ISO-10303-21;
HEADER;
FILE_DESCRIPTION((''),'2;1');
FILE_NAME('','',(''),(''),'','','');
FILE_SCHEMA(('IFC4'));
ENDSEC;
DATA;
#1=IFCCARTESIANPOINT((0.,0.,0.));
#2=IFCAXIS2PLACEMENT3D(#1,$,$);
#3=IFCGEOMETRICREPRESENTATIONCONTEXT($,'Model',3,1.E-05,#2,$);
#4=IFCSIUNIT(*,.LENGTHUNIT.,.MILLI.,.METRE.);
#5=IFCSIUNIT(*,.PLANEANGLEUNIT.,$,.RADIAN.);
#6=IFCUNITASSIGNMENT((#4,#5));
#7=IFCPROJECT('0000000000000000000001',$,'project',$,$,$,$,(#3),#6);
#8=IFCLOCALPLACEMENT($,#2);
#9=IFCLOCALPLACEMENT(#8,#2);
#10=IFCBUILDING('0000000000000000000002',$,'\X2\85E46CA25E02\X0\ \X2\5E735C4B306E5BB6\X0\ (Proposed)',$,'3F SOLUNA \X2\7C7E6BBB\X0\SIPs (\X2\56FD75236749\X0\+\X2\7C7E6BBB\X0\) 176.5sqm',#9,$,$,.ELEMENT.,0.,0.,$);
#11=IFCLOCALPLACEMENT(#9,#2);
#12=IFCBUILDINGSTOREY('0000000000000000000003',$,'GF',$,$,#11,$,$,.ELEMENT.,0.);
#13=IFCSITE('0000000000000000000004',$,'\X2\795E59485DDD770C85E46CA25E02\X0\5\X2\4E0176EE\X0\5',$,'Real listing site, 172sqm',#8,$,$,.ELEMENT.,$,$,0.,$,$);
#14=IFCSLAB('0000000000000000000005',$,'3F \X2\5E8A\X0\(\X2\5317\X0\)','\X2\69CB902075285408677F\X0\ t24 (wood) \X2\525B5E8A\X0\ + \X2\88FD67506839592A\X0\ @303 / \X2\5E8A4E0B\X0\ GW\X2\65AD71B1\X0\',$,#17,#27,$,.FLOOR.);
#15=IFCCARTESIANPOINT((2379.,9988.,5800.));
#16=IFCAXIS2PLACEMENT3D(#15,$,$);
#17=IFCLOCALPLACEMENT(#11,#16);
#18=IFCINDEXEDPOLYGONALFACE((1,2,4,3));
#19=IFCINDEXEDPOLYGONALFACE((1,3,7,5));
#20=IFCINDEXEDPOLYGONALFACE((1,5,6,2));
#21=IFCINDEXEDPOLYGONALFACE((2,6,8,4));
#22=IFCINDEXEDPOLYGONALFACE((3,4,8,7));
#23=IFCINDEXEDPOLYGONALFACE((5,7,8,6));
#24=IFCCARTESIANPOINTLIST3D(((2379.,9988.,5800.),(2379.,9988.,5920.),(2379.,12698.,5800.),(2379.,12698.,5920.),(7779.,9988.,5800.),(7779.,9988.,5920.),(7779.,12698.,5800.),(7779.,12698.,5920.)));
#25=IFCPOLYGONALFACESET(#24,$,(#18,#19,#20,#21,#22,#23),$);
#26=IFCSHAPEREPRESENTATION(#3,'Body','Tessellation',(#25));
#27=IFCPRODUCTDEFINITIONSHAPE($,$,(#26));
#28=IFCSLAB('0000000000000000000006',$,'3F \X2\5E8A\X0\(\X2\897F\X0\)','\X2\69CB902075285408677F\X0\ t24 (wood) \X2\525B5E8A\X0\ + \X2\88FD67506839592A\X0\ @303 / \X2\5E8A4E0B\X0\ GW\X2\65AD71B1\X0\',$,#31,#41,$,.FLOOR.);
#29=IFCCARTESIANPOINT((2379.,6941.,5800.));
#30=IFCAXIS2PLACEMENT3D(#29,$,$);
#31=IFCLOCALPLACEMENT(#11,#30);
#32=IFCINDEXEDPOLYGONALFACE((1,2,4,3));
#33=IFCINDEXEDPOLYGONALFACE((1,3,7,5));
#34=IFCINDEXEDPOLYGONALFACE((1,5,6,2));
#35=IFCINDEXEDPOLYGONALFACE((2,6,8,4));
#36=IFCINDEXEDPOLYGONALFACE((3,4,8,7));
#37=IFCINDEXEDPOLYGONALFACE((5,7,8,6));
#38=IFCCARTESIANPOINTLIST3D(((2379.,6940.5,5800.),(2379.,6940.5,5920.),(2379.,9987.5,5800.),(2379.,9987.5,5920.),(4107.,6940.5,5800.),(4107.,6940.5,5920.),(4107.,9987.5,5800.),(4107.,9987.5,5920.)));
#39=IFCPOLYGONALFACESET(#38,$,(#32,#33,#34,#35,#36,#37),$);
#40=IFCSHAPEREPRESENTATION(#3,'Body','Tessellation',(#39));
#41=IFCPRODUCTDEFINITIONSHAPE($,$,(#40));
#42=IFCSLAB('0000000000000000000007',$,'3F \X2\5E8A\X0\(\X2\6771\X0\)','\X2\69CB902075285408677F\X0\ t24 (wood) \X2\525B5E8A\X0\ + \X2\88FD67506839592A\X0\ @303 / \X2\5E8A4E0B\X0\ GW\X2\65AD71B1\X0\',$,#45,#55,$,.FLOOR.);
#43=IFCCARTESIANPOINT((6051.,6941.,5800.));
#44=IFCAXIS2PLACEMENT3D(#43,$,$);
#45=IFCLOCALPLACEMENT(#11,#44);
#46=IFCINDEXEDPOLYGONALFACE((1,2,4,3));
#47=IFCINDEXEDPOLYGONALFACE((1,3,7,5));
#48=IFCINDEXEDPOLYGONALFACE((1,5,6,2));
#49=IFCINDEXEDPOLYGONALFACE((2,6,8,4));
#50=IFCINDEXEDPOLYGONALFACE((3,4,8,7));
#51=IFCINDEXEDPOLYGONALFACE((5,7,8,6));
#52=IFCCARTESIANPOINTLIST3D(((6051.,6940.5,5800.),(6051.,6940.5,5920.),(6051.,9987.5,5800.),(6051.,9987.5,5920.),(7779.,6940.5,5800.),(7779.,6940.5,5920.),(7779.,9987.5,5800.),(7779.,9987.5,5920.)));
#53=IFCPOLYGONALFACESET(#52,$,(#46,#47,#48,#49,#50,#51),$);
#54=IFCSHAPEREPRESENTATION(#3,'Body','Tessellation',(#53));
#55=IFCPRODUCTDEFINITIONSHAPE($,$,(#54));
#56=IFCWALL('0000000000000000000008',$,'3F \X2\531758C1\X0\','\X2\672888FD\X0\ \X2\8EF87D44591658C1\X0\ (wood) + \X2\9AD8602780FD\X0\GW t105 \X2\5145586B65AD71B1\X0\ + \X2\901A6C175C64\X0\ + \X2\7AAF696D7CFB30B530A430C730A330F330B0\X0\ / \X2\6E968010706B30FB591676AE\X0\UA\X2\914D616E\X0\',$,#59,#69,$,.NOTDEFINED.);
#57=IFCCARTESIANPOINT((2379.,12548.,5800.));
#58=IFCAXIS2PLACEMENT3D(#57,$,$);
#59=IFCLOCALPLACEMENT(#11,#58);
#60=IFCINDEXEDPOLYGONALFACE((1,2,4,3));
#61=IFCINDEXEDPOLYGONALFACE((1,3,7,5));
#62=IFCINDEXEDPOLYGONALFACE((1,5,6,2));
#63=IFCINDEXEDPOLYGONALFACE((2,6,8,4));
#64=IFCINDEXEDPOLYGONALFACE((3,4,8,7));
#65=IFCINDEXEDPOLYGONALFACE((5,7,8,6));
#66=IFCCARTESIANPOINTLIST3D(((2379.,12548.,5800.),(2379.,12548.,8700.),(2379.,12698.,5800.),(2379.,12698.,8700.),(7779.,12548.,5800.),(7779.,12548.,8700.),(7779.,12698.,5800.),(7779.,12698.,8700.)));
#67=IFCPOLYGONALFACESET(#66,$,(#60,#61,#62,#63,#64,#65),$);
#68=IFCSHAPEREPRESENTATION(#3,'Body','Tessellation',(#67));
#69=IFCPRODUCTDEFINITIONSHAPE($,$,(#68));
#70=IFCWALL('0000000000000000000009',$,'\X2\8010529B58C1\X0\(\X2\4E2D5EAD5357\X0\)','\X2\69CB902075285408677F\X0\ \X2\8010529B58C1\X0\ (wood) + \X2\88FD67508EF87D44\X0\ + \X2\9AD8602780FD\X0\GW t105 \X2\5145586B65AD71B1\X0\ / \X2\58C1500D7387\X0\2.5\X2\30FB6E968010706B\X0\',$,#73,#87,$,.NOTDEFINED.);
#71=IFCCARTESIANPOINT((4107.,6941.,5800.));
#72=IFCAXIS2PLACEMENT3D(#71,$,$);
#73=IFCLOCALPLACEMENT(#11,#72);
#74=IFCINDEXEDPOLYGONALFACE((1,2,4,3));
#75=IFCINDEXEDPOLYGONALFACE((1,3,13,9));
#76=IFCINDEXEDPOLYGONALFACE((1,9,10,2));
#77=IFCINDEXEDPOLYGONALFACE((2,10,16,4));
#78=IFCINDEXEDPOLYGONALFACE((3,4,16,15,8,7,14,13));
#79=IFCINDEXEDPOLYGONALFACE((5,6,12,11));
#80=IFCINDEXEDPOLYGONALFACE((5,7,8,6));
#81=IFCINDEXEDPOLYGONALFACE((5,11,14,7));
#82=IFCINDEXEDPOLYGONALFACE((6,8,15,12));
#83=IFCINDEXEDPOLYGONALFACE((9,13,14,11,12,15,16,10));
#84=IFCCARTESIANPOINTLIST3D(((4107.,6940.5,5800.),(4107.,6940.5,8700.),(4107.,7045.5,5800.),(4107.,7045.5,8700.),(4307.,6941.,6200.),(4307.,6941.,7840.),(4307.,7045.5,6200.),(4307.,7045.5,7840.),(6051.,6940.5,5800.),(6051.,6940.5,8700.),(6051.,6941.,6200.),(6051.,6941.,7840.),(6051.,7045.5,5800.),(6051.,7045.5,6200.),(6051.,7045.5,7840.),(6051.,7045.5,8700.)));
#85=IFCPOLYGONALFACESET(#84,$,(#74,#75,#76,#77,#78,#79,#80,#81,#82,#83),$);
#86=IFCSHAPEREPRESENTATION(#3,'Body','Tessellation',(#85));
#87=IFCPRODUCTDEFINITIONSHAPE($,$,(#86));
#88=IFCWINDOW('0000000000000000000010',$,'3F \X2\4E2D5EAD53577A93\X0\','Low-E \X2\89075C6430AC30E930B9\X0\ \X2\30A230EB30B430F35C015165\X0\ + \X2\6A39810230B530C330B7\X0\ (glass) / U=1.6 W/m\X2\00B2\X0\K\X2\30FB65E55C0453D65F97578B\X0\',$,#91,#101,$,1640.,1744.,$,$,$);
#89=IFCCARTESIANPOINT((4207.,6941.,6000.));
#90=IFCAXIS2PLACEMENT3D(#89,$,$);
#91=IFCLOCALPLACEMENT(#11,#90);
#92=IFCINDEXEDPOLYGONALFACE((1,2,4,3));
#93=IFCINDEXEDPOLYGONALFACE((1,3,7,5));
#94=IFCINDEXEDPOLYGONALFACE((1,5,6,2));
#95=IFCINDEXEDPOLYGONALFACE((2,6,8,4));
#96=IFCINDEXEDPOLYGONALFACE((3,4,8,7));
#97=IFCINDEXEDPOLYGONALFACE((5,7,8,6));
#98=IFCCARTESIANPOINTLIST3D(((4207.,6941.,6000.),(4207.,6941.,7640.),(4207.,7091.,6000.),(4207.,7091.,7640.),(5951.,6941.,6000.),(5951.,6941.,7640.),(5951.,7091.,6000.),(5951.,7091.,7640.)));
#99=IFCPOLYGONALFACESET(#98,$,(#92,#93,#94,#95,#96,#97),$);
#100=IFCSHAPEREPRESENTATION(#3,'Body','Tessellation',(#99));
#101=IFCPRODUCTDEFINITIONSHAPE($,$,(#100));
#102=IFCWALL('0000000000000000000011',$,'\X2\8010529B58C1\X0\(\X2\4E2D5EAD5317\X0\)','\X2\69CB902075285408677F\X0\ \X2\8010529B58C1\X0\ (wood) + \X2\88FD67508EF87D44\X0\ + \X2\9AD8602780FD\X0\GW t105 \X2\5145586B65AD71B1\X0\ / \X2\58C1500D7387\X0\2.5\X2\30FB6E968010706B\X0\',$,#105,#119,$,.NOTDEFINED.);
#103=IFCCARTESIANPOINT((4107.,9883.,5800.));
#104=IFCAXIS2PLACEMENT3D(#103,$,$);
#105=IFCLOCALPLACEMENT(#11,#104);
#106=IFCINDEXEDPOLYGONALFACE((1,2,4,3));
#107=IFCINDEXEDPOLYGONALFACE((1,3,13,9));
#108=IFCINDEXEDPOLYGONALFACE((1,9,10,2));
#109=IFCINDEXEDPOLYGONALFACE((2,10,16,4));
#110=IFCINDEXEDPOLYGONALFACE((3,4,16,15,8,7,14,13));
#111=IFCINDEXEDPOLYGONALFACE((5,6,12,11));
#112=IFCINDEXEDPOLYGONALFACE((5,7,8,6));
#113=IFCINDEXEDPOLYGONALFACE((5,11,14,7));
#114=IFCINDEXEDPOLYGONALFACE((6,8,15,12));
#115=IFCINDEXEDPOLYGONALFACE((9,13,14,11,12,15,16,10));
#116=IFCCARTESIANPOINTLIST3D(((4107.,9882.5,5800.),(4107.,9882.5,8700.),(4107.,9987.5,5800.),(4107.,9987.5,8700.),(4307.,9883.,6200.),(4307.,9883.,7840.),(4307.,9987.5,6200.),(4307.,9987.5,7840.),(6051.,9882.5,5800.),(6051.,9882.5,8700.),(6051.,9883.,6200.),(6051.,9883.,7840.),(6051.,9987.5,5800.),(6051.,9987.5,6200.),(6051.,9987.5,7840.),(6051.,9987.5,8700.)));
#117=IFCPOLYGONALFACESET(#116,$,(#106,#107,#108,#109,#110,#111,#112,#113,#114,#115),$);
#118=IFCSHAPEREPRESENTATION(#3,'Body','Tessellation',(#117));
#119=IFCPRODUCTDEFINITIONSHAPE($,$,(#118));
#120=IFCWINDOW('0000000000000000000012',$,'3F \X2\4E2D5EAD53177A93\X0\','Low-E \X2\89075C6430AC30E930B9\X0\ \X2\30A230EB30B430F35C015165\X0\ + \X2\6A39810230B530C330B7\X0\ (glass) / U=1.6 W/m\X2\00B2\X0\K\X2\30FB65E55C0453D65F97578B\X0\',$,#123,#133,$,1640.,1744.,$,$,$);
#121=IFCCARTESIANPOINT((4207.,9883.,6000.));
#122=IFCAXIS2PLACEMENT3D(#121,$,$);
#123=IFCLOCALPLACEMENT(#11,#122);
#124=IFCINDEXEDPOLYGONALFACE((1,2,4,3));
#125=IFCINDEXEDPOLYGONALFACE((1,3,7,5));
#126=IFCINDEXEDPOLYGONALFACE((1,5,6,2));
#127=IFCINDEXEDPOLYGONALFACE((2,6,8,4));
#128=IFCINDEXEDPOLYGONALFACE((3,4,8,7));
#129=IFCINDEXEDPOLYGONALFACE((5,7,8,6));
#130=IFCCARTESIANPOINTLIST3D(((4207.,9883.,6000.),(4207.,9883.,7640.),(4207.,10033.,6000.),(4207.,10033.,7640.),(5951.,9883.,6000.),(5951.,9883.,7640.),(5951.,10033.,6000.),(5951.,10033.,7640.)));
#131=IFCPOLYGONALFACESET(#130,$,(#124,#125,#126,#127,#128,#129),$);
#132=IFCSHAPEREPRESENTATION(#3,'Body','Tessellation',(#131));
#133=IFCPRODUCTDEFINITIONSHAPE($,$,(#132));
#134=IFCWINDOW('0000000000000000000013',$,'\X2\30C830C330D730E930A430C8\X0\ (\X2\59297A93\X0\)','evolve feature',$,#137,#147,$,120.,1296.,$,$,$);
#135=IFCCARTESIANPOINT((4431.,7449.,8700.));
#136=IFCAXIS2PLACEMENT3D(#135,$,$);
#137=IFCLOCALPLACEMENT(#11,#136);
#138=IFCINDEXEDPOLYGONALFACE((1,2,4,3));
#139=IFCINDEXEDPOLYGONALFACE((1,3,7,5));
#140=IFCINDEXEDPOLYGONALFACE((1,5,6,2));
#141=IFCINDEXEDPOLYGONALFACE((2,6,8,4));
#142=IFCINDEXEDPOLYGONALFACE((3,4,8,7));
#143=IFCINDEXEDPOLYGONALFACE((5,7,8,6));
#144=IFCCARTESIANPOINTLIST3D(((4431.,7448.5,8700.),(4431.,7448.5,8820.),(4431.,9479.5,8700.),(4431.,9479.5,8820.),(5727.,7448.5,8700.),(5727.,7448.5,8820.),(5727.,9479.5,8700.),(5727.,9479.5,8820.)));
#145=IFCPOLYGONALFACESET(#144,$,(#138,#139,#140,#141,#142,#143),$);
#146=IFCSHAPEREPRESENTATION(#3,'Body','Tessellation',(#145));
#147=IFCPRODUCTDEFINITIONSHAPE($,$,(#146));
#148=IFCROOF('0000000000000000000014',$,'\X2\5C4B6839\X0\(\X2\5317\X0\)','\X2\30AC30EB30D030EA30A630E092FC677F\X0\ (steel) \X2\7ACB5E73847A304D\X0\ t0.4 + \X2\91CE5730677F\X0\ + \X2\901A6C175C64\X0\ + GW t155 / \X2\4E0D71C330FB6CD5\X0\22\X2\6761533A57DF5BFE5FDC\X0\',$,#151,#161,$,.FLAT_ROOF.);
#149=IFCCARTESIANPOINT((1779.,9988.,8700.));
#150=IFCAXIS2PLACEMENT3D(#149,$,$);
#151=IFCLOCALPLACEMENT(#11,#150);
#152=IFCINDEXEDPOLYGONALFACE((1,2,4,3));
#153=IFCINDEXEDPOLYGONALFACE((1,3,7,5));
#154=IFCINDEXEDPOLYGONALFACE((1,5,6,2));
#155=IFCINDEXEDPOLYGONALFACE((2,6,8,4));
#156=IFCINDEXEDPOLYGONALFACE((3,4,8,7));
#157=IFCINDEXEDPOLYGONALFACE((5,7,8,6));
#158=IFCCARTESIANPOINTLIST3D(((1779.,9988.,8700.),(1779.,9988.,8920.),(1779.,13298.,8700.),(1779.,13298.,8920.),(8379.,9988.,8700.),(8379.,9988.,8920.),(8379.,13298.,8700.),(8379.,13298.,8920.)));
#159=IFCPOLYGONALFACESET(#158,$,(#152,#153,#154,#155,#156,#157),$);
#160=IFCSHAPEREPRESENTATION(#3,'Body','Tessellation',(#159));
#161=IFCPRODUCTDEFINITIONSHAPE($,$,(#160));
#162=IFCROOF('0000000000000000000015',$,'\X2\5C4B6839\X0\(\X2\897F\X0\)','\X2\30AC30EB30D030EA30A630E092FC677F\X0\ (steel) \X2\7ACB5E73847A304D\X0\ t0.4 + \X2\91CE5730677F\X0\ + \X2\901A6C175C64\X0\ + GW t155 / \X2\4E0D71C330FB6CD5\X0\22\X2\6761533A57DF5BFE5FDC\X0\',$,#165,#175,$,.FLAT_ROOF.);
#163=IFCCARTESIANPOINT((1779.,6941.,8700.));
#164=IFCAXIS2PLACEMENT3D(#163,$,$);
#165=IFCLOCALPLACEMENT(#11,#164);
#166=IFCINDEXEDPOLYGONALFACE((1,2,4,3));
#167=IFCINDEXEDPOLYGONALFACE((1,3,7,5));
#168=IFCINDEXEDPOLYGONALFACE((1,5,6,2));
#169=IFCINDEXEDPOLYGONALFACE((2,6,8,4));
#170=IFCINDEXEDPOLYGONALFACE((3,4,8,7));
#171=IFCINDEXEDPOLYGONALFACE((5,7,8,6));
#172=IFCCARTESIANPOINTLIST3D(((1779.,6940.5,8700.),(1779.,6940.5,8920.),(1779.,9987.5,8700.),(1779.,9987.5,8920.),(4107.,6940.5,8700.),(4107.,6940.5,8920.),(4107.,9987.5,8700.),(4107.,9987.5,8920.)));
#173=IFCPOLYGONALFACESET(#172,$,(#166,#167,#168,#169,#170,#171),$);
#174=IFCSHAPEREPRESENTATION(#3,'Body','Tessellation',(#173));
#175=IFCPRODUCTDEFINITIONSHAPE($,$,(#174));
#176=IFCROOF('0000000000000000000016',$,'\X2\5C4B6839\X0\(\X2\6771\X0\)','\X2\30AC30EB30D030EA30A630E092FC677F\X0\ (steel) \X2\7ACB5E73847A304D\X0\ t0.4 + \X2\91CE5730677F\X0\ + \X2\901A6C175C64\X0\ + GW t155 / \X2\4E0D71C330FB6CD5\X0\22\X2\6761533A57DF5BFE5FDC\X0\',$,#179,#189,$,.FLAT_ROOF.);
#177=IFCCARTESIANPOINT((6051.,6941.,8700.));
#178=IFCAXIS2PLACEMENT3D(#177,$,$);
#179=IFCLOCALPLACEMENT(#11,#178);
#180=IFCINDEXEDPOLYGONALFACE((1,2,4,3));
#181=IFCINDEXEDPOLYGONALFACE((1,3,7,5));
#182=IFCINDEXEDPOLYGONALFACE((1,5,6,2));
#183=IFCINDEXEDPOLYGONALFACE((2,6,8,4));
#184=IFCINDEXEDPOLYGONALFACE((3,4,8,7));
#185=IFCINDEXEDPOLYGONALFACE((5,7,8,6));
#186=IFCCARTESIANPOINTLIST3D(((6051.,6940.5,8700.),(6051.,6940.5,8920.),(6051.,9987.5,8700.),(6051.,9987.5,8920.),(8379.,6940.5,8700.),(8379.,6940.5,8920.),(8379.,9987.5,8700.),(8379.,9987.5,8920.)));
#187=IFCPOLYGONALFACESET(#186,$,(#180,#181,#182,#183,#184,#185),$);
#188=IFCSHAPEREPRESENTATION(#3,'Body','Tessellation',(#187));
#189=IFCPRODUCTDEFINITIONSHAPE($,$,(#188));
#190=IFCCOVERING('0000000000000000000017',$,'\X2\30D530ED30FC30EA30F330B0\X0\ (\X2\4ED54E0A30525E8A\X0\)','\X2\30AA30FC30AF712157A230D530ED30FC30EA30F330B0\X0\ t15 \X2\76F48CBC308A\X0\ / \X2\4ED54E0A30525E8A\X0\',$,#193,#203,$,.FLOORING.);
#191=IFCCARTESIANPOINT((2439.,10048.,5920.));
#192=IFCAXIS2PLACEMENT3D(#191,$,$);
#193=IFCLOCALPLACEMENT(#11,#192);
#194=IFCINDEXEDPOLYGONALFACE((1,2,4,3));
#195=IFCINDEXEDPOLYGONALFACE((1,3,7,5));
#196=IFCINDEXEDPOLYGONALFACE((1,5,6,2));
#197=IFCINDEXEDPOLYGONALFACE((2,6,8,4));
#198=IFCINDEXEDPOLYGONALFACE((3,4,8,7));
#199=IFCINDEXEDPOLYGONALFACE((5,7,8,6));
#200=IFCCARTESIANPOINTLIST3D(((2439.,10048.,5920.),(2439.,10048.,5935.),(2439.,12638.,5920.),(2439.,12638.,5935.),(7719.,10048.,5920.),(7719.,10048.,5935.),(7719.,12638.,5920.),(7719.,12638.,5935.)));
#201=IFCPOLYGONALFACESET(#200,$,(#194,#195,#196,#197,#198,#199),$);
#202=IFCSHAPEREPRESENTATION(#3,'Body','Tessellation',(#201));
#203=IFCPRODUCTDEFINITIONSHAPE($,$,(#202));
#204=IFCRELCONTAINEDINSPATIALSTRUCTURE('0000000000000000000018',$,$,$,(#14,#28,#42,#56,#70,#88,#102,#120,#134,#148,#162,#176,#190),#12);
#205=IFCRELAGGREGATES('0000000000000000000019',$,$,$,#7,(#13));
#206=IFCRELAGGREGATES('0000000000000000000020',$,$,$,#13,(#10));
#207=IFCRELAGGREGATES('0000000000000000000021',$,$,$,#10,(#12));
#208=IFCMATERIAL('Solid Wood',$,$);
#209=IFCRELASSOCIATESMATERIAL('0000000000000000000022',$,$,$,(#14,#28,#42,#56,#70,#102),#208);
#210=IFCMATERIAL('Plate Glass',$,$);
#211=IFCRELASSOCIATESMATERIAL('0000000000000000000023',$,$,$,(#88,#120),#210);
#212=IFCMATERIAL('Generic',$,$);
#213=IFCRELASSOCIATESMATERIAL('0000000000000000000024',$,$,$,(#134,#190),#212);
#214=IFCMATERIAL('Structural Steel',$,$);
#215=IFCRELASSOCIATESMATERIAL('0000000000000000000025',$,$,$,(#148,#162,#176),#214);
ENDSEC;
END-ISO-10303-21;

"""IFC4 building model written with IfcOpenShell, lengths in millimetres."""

from ifc_helpers import new_model, si_unit, frame, frame_2d, origin, place, context, project, spatial, rectangle, extrude, material, element, fill, save


model = new_model("IFC4")

# Units and contexts
model_context = context("Model", 3, precision=1e-05, world=origin())
ifc_project = project(units=[si_unit("LENGTHUNIT", "METRE", prefix="MILLI"), si_unit("PLANEANGLEUNIT", "RADIAN")], contexts=[model_context])

# Site, building, storey
site_placement = place(None, origin())
site = spatial("IfcSite", under=ifc_project, at=site_placement, Name="神奈川県藤沢市5丁目5", ObjectType="Real listing site, 172sqm", CompositionType="ELEMENT", RefElevation=0.0)
building_placement = place(site_placement, origin())
building = spatial("IfcBuilding", under=site, at=building_placement, Name="藤沢市 平屋の家 (Proposed)", ObjectType="3F SOLUNA 籾殻SIPs (国産杉+籾殻) 176.5sqm", CompositionType="ELEMENT", ElevationOfRefHeight=0.0, ElevationOfTerrain=0.0)
storey_placement = place(building_placement, origin())
storey = spatial("IfcBuildingStorey", under=building, at=storey_placement, Name="GF", CompositionType="ELEMENT", Elevation=0.0)

# Slabs
ifc_material_1 = material(Name="Solid Wood")
slab_1_placement = place(storey_placement, frame((2379.0, 9988.0, 5800.0)))
element("IfcSlab", 1, at=slab_1_placement, inside=storey, material=ifc_material_1, Name="3F 床(北)", Description="構造用合板 t24 (wood) 剛床 + 製材根太 @303 / 床下 GW断熱", PredefinedType="FLOOR", context=model_context, shape_type="SweptSolid", body=[
    extrude(rectangle(XDim=5400.0, YDim=2710.0, at=frame_2d((2700.0, 1355.0))), frame((2379.0, 9988.0, 5800.0)), (0.0, 0.0, 1.0), 120.0),
])
slab_2_placement = place(storey_placement, frame((2379.0, 6941.0, 5800.0)))
element("IfcSlab", 2, at=slab_2_placement, inside=storey, material=ifc_material_1, Name="3F 床(西)", Description="構造用合板 t24 (wood) 剛床 + 製材根太 @303 / 床下 GW断熱", PredefinedType="FLOOR", context=model_context, shape_type="SweptSolid", body=[
    extrude(rectangle(XDim=1728.0, YDim=3047.0, at=frame_2d((864.0, 1523.0))), frame((2379.0, 6941.0, 5800.0)), (0.0, 0.0, 1.0), 120.0),
])
slab_3_placement = place(storey_placement, frame((6051.0, 6941.0, 5800.0)))
element("IfcSlab", 3, at=slab_3_placement, inside=storey, material=ifc_material_1, Name="3F 床(東)", Description="構造用合板 t24 (wood) 剛床 + 製材根太 @303 / 床下 GW断熱", PredefinedType="FLOOR", context=model_context, shape_type="SweptSolid", body=[
    extrude(rectangle(XDim=1728.0, YDim=3047.0, at=frame_2d((864.0, 1523.0))), frame((6051.0, 6941.0, 5800.0)), (0.0, 0.0, 1.0), 120.0),
])

# Wall
wall_1_placement = place(storey_placement, frame((2379.0, 12548.0, 5800.0)))
element("IfcWall", 4, at=wall_1_placement, inside=storey, material=ifc_material_1, Name="3F 北壁", Description="木製 軸組外壁 (wood) + 高性能GW t105 充填断熱 + 通気層 + 窯業系サイディング / 準耐火・外皮UA配慮", PredefinedType="NOTDEFINED", context=model_context, shape_type="SweptSolid", body=[
    extrude(rectangle(XDim=5400.0, YDim=150.0, at=frame_2d((2700.0, 75.0))), frame((2379.0, 12548.0, 5800.0)), (0.0, 0.0, 1.0), 2900.0),
])

# Walls, openings, windows
wall_2_placement = place(storey_placement, frame((4107.0, 6941.0, 5800.0)))
wall_2 = element("IfcWall", 5, at=wall_2_placement, inside=storey, material=ifc_material_1, Name="耐力壁(中庭南)", Description="構造用合板 耐力壁 (wood) + 製材軸組 + 高性能GW t105 充填断熱 / 壁倍率2.5・準耐火", PredefinedType="NOTDEFINED", context=model_context, shape_type="SweptSolid", body=[
    extrude(rectangle(XDim=1944.0, YDim=105.0, at=frame_2d((972.0, 52.0))), frame((4107.0, 6941.0, 5800.0)), (0.0, 0.0, 1.0), 2900.0),
])
opening_1_placement = place(storey_placement, frame((4207.0, 6941.0, 6000.0)))
opening_1 = element("IfcOpeningElement", 6, at=opening_1_placement, cuts=wall_2, PredefinedType="NOTDEFINED", context=model_context, shape_type="SweptSolid", body=[
    extrude(rectangle(XDim=1744.0, YDim=150.0, at=frame_2d((872.0, 75.0))), frame((4207.0, 6941.0, 6000.0)), (0.0, 0.0, 1.0), 1640.0),
])
ifc_material_2 = material(Name="Plate Glass")
window_1_placement = place(storey_placement, frame((4207.0, 6941.0, 6000.0)))
window_1 = element("IfcWindow", 7, at=window_1_placement, inside=storey, material=ifc_material_2, Name="3F 中庭南窓", Description="Low-E 複層ガラス アルゴン封入 + 樹脂サッシ (glass) / U=1.6 W/m²K・日射取得型", OverallHeight=1640.0, OverallWidth=1744.0, context=model_context, shape_type="SweptSolid", body=[
    extrude(rectangle(XDim=1744.0, YDim=150.0, at=frame_2d((872.0, 75.0))), frame((4207.0, 6941.0, 6000.0)), (0.0, 0.0, 1.0), 1640.0),
])
fill(opening_1, window_1)
wall_3_placement = place(storey_placement, frame((4107.0, 9883.0, 5800.0)))
wall_3 = element("IfcWall", 8, at=wall_3_placement, inside=storey, material=ifc_material_1, Name="耐力壁(中庭北)", Description="構造用合板 耐力壁 (wood) + 製材軸組 + 高性能GW t105 充填断熱 / 壁倍率2.5・準耐火", PredefinedType="NOTDEFINED", context=model_context, shape_type="SweptSolid", body=[
    extrude(rectangle(XDim=1944.0, YDim=105.0, at=frame_2d((972.0, 52.0))), frame((4107.0, 9883.0, 5800.0)), (0.0, 0.0, 1.0), 2900.0),
])
opening_2_placement = place(storey_placement, frame((4207.0, 9883.0, 6000.0)))
opening_2 = element("IfcOpeningElement", 9, at=opening_2_placement, cuts=wall_3, PredefinedType="NOTDEFINED", context=model_context, shape_type="SweptSolid", body=[
    extrude(rectangle(XDim=1744.0, YDim=150.0, at=frame_2d((872.0, 75.0))), frame((4207.0, 9883.0, 6000.0)), (0.0, 0.0, 1.0), 1640.0),
])
window_2_placement = place(storey_placement, frame((4207.0, 9883.0, 6000.0)))
window_2 = element("IfcWindow", 10, at=window_2_placement, inside=storey, material=ifc_material_2, Name="3F 中庭北窓", Description="Low-E 複層ガラス アルゴン封入 + 樹脂サッシ (glass) / U=1.6 W/m²K・日射取得型", OverallHeight=1640.0, OverallWidth=1744.0, context=model_context, shape_type="SweptSolid", body=[
    extrude(rectangle(XDim=1744.0, YDim=150.0, at=frame_2d((872.0, 75.0))), frame((4207.0, 9883.0, 6000.0)), (0.0, 0.0, 1.0), 1640.0),
])
fill(opening_2, window_2)

# Window
ifc_material_3 = material(Name="Generic")
window_3_placement = place(storey_placement, frame((4431.0, 7449.0, 8700.0)))
element("IfcWindow", 11, at=window_3_placement, inside=storey, material=ifc_material_3, Name="トップライト (天窓)", Description="evolve feature", OverallHeight=120.0, OverallWidth=1296.0, context=model_context, shape_type="SweptSolid", body=[
    extrude(rectangle(XDim=1296.0, YDim=2031.0, at=frame_2d((648.0, 1015.0))), frame((4431.0, 7449.0, 8700.0)), (0.0, 0.0, 1.0), 120.0),
])

# Roofs
ifc_material_4 = material(Name="Structural Steel")
for number, where, name in (
    (12, (1779.0, 9988.0, 8700.0), "屋根(北)"),
):
    element("IfcRoof", number, at=place(storey_placement, frame(where)), inside=storey, material=ifc_material_4, Name=name, Description="ガルバリウム鋼板 (steel) 立平葺き t0.4 + 野地板 + 通気層 + GW t155 / 不燃・法22条区域対応", PredefinedType="FLAT_ROOF", context=model_context, shape_type="SweptSolid", body=[
        extrude(rectangle(XDim=6600.0, YDim=3310.0, at=frame_2d((3300.0, 1655.0))), frame((1779.0, 9988.0, 8700.0)), (0.0, 0.0, 1.0), 220.0),
    ])
roof_1_placement = place(storey_placement, frame((1779.0, 6941.0, 8700.0)))
element("IfcRoof", 13, at=roof_1_placement, inside=storey, material=ifc_material_4, Name="屋根(西)", Description="ガルバリウム鋼板 (steel) 立平葺き t0.4 + 野地板 + 通気層 + GW t155 / 不燃・法22条区域対応", PredefinedType="FLAT_ROOF", context=model_context, shape_type="SweptSolid", body=[
    extrude(rectangle(XDim=2328.0, YDim=3047.0, at=frame_2d((1164.0, 1523.0))), frame((1779.0, 6941.0, 8700.0)), (0.0, 0.0, 1.0), 220.0),
])
roof_2_placement = place(storey_placement, frame((6051.0, 6941.0, 8700.0)))
element("IfcRoof", 14, at=roof_2_placement, inside=storey, material=ifc_material_4, Name="屋根(東)", Description="ガルバリウム鋼板 (steel) 立平葺き t0.4 + 野地板 + 通気層 + GW t155 / 不燃・法22条区域対応", PredefinedType="FLAT_ROOF", context=model_context, shape_type="SweptSolid", body=[
    extrude(rectangle(XDim=2328.0, YDim=3047.0, at=frame_2d((1164.0, 1523.0))), frame((6051.0, 6941.0, 8700.0)), (0.0, 0.0, 1.0), 220.0),
])

# Covering
covering_1_placement = place(storey_placement, frame((2439.0, 10048.0, 5920.0)))
element("IfcCovering", 15, at=covering_1_placement, inside=storey, material=ifc_material_3, Name="フローリング (仕上げ床)", Description="オーク無垢フローリング t15 直貼り / 仕上げ床", PredefinedType="FLOORING", context=model_context, shape_type="SweptSolid", body=[
    extrude(rectangle(XDim=5280.0, YDim=2590.0, at=frame_2d((2640.0, 1295.0))), frame((2439.0, 10048.0, 5920.0)), (0.0, 0.0, 1.0), 15.0),
])

save(model, "model.ifc")
